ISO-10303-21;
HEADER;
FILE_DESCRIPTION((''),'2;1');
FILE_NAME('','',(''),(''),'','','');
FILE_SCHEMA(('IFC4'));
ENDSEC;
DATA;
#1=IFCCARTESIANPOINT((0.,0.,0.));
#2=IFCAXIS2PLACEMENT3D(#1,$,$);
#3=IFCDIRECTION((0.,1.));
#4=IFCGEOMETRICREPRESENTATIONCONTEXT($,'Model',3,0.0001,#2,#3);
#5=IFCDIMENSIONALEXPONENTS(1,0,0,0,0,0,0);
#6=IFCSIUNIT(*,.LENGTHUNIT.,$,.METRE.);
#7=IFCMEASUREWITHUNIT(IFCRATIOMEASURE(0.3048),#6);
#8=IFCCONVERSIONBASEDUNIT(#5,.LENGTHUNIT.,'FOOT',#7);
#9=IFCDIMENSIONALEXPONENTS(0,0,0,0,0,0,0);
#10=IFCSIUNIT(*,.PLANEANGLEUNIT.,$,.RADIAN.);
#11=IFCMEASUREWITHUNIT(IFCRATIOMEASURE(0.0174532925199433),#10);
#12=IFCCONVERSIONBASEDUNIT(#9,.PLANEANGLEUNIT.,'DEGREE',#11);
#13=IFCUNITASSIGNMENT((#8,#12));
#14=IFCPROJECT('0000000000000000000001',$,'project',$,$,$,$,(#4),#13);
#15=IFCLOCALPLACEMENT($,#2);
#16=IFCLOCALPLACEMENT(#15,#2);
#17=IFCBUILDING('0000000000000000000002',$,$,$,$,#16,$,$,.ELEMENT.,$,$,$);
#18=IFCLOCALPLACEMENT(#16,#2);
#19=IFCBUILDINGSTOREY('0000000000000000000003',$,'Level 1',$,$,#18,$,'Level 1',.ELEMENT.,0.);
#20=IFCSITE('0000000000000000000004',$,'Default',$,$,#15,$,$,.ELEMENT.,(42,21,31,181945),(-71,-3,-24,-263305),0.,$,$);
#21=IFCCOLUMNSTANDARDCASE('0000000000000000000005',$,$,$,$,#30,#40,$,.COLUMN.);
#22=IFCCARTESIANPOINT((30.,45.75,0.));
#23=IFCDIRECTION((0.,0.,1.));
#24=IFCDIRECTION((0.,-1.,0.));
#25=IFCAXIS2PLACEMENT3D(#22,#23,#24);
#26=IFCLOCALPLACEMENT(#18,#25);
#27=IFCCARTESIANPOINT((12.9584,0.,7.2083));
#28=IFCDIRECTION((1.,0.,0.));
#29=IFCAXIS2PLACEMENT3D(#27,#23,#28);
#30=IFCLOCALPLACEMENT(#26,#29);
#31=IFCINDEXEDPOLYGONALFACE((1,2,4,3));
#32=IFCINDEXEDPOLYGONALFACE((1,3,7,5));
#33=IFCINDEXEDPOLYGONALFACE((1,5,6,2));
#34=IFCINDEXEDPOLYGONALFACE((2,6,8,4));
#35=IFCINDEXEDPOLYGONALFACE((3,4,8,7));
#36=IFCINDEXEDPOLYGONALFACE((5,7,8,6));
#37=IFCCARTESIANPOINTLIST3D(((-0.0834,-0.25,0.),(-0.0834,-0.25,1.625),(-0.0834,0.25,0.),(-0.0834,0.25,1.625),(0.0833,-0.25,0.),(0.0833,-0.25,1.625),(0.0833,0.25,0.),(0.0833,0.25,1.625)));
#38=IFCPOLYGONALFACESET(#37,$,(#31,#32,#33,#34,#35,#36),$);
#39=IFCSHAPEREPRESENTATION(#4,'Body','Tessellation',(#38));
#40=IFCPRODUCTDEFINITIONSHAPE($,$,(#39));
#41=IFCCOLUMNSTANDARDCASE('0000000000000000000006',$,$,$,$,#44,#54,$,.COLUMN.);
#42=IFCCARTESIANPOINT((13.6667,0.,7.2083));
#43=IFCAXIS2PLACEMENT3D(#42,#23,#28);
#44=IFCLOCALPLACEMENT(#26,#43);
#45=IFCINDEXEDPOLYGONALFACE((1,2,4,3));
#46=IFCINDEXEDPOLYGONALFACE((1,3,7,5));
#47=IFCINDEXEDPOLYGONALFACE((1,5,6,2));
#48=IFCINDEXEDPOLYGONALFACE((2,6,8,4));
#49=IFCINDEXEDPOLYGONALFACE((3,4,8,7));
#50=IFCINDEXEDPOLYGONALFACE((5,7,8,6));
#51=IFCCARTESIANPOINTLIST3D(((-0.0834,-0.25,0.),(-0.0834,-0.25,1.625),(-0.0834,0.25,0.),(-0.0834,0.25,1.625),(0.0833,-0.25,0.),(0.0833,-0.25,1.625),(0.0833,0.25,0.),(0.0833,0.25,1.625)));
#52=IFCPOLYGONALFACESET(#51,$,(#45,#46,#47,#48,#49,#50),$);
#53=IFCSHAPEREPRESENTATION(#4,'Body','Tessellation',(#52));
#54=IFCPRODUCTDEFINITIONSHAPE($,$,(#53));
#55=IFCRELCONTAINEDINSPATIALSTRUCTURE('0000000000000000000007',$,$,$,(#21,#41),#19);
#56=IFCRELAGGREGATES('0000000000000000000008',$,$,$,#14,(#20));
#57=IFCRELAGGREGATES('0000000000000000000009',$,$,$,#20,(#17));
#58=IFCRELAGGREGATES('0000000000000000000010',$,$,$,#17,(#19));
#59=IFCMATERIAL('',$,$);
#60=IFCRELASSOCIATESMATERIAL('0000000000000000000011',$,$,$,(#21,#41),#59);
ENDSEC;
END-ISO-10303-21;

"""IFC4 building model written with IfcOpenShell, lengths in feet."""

from ifc_helpers import new_model, entity, si_unit, converted_unit, direction, frame, origin, place, context, project, spatial, rectangle, extrude, material, element, save


model = new_model("IFC4")

# Units and contexts
model_context = context("Model", 3, precision=0.0001, world=origin(), true_north=direction((0.0, 1.0)))
ifc_project = project(units=[converted_unit("LENGTHUNIT", "FOOT", entity("IfcRatioMeasure", 0.3048), si_unit("LENGTHUNIT", "METRE"), dimensions=[1, 0, 0, 0, 0, 0, 0]), converted_unit("PLANEANGLEUNIT", "DEGREE", entity("IfcRatioMeasure", 0.0174532925199433), si_unit("PLANEANGLEUNIT", "RADIAN"), dimensions=[0, 0, 0, 0, 0, 0, 0])], contexts=[model_context])

# Site, building, storey
site_placement = place(None, origin())
site = spatial("IfcSite", under=ifc_project, at=site_placement, Name="Default", CompositionType="ELEMENT", RefLatitude=(42, 21, 31, 181945), RefLongitude=(-71, -3, -24, -263305), RefElevation=0.0)
building_placement = place(site_placement, origin())
building = spatial("IfcBuilding", under=site, at=building_placement, CompositionType="ELEMENT")
storey_placement = place(building_placement, origin())
storey = spatial("IfcBuildingStorey", under=building, at=storey_placement, Name="Level 1", LongName="Level 1", CompositionType="ELEMENT", Elevation=0.0)

# Columns
placement_1 = place(storey_placement, frame((30.0, 45.75, 0.0), z_axis=(0.0, 0.0, 1.0), x_axis=(0.0, -1.0, 0.0)))
ifc_material_1 = material(Name="")
for number, where, z_axis, x_axis in (
    (1, (12.9584, 0.0, 7.2083), (0.0, 0.0, 1.0), (1.0, 0.0, 0.0)),
    (2, (13.6667, 0.0, 7.2083), (0.0, 0.0, 1.0), (1.0, 0.0, 0.0)),
):
    element("IfcColumnStandardCase", number, at=place(placement_1, frame(where, z_axis=z_axis, x_axis=x_axis)), inside=storey, material=ifc_material_1, PredefinedType="COLUMN", context=model_context, shape_type="SweptSolid", body=[
        extrude(rectangle(XDim=0.1667, YDim=0.5), origin(), (0.0, 0.0, 1.0), 1.625),
    ])

save(model, "model.ifc")
